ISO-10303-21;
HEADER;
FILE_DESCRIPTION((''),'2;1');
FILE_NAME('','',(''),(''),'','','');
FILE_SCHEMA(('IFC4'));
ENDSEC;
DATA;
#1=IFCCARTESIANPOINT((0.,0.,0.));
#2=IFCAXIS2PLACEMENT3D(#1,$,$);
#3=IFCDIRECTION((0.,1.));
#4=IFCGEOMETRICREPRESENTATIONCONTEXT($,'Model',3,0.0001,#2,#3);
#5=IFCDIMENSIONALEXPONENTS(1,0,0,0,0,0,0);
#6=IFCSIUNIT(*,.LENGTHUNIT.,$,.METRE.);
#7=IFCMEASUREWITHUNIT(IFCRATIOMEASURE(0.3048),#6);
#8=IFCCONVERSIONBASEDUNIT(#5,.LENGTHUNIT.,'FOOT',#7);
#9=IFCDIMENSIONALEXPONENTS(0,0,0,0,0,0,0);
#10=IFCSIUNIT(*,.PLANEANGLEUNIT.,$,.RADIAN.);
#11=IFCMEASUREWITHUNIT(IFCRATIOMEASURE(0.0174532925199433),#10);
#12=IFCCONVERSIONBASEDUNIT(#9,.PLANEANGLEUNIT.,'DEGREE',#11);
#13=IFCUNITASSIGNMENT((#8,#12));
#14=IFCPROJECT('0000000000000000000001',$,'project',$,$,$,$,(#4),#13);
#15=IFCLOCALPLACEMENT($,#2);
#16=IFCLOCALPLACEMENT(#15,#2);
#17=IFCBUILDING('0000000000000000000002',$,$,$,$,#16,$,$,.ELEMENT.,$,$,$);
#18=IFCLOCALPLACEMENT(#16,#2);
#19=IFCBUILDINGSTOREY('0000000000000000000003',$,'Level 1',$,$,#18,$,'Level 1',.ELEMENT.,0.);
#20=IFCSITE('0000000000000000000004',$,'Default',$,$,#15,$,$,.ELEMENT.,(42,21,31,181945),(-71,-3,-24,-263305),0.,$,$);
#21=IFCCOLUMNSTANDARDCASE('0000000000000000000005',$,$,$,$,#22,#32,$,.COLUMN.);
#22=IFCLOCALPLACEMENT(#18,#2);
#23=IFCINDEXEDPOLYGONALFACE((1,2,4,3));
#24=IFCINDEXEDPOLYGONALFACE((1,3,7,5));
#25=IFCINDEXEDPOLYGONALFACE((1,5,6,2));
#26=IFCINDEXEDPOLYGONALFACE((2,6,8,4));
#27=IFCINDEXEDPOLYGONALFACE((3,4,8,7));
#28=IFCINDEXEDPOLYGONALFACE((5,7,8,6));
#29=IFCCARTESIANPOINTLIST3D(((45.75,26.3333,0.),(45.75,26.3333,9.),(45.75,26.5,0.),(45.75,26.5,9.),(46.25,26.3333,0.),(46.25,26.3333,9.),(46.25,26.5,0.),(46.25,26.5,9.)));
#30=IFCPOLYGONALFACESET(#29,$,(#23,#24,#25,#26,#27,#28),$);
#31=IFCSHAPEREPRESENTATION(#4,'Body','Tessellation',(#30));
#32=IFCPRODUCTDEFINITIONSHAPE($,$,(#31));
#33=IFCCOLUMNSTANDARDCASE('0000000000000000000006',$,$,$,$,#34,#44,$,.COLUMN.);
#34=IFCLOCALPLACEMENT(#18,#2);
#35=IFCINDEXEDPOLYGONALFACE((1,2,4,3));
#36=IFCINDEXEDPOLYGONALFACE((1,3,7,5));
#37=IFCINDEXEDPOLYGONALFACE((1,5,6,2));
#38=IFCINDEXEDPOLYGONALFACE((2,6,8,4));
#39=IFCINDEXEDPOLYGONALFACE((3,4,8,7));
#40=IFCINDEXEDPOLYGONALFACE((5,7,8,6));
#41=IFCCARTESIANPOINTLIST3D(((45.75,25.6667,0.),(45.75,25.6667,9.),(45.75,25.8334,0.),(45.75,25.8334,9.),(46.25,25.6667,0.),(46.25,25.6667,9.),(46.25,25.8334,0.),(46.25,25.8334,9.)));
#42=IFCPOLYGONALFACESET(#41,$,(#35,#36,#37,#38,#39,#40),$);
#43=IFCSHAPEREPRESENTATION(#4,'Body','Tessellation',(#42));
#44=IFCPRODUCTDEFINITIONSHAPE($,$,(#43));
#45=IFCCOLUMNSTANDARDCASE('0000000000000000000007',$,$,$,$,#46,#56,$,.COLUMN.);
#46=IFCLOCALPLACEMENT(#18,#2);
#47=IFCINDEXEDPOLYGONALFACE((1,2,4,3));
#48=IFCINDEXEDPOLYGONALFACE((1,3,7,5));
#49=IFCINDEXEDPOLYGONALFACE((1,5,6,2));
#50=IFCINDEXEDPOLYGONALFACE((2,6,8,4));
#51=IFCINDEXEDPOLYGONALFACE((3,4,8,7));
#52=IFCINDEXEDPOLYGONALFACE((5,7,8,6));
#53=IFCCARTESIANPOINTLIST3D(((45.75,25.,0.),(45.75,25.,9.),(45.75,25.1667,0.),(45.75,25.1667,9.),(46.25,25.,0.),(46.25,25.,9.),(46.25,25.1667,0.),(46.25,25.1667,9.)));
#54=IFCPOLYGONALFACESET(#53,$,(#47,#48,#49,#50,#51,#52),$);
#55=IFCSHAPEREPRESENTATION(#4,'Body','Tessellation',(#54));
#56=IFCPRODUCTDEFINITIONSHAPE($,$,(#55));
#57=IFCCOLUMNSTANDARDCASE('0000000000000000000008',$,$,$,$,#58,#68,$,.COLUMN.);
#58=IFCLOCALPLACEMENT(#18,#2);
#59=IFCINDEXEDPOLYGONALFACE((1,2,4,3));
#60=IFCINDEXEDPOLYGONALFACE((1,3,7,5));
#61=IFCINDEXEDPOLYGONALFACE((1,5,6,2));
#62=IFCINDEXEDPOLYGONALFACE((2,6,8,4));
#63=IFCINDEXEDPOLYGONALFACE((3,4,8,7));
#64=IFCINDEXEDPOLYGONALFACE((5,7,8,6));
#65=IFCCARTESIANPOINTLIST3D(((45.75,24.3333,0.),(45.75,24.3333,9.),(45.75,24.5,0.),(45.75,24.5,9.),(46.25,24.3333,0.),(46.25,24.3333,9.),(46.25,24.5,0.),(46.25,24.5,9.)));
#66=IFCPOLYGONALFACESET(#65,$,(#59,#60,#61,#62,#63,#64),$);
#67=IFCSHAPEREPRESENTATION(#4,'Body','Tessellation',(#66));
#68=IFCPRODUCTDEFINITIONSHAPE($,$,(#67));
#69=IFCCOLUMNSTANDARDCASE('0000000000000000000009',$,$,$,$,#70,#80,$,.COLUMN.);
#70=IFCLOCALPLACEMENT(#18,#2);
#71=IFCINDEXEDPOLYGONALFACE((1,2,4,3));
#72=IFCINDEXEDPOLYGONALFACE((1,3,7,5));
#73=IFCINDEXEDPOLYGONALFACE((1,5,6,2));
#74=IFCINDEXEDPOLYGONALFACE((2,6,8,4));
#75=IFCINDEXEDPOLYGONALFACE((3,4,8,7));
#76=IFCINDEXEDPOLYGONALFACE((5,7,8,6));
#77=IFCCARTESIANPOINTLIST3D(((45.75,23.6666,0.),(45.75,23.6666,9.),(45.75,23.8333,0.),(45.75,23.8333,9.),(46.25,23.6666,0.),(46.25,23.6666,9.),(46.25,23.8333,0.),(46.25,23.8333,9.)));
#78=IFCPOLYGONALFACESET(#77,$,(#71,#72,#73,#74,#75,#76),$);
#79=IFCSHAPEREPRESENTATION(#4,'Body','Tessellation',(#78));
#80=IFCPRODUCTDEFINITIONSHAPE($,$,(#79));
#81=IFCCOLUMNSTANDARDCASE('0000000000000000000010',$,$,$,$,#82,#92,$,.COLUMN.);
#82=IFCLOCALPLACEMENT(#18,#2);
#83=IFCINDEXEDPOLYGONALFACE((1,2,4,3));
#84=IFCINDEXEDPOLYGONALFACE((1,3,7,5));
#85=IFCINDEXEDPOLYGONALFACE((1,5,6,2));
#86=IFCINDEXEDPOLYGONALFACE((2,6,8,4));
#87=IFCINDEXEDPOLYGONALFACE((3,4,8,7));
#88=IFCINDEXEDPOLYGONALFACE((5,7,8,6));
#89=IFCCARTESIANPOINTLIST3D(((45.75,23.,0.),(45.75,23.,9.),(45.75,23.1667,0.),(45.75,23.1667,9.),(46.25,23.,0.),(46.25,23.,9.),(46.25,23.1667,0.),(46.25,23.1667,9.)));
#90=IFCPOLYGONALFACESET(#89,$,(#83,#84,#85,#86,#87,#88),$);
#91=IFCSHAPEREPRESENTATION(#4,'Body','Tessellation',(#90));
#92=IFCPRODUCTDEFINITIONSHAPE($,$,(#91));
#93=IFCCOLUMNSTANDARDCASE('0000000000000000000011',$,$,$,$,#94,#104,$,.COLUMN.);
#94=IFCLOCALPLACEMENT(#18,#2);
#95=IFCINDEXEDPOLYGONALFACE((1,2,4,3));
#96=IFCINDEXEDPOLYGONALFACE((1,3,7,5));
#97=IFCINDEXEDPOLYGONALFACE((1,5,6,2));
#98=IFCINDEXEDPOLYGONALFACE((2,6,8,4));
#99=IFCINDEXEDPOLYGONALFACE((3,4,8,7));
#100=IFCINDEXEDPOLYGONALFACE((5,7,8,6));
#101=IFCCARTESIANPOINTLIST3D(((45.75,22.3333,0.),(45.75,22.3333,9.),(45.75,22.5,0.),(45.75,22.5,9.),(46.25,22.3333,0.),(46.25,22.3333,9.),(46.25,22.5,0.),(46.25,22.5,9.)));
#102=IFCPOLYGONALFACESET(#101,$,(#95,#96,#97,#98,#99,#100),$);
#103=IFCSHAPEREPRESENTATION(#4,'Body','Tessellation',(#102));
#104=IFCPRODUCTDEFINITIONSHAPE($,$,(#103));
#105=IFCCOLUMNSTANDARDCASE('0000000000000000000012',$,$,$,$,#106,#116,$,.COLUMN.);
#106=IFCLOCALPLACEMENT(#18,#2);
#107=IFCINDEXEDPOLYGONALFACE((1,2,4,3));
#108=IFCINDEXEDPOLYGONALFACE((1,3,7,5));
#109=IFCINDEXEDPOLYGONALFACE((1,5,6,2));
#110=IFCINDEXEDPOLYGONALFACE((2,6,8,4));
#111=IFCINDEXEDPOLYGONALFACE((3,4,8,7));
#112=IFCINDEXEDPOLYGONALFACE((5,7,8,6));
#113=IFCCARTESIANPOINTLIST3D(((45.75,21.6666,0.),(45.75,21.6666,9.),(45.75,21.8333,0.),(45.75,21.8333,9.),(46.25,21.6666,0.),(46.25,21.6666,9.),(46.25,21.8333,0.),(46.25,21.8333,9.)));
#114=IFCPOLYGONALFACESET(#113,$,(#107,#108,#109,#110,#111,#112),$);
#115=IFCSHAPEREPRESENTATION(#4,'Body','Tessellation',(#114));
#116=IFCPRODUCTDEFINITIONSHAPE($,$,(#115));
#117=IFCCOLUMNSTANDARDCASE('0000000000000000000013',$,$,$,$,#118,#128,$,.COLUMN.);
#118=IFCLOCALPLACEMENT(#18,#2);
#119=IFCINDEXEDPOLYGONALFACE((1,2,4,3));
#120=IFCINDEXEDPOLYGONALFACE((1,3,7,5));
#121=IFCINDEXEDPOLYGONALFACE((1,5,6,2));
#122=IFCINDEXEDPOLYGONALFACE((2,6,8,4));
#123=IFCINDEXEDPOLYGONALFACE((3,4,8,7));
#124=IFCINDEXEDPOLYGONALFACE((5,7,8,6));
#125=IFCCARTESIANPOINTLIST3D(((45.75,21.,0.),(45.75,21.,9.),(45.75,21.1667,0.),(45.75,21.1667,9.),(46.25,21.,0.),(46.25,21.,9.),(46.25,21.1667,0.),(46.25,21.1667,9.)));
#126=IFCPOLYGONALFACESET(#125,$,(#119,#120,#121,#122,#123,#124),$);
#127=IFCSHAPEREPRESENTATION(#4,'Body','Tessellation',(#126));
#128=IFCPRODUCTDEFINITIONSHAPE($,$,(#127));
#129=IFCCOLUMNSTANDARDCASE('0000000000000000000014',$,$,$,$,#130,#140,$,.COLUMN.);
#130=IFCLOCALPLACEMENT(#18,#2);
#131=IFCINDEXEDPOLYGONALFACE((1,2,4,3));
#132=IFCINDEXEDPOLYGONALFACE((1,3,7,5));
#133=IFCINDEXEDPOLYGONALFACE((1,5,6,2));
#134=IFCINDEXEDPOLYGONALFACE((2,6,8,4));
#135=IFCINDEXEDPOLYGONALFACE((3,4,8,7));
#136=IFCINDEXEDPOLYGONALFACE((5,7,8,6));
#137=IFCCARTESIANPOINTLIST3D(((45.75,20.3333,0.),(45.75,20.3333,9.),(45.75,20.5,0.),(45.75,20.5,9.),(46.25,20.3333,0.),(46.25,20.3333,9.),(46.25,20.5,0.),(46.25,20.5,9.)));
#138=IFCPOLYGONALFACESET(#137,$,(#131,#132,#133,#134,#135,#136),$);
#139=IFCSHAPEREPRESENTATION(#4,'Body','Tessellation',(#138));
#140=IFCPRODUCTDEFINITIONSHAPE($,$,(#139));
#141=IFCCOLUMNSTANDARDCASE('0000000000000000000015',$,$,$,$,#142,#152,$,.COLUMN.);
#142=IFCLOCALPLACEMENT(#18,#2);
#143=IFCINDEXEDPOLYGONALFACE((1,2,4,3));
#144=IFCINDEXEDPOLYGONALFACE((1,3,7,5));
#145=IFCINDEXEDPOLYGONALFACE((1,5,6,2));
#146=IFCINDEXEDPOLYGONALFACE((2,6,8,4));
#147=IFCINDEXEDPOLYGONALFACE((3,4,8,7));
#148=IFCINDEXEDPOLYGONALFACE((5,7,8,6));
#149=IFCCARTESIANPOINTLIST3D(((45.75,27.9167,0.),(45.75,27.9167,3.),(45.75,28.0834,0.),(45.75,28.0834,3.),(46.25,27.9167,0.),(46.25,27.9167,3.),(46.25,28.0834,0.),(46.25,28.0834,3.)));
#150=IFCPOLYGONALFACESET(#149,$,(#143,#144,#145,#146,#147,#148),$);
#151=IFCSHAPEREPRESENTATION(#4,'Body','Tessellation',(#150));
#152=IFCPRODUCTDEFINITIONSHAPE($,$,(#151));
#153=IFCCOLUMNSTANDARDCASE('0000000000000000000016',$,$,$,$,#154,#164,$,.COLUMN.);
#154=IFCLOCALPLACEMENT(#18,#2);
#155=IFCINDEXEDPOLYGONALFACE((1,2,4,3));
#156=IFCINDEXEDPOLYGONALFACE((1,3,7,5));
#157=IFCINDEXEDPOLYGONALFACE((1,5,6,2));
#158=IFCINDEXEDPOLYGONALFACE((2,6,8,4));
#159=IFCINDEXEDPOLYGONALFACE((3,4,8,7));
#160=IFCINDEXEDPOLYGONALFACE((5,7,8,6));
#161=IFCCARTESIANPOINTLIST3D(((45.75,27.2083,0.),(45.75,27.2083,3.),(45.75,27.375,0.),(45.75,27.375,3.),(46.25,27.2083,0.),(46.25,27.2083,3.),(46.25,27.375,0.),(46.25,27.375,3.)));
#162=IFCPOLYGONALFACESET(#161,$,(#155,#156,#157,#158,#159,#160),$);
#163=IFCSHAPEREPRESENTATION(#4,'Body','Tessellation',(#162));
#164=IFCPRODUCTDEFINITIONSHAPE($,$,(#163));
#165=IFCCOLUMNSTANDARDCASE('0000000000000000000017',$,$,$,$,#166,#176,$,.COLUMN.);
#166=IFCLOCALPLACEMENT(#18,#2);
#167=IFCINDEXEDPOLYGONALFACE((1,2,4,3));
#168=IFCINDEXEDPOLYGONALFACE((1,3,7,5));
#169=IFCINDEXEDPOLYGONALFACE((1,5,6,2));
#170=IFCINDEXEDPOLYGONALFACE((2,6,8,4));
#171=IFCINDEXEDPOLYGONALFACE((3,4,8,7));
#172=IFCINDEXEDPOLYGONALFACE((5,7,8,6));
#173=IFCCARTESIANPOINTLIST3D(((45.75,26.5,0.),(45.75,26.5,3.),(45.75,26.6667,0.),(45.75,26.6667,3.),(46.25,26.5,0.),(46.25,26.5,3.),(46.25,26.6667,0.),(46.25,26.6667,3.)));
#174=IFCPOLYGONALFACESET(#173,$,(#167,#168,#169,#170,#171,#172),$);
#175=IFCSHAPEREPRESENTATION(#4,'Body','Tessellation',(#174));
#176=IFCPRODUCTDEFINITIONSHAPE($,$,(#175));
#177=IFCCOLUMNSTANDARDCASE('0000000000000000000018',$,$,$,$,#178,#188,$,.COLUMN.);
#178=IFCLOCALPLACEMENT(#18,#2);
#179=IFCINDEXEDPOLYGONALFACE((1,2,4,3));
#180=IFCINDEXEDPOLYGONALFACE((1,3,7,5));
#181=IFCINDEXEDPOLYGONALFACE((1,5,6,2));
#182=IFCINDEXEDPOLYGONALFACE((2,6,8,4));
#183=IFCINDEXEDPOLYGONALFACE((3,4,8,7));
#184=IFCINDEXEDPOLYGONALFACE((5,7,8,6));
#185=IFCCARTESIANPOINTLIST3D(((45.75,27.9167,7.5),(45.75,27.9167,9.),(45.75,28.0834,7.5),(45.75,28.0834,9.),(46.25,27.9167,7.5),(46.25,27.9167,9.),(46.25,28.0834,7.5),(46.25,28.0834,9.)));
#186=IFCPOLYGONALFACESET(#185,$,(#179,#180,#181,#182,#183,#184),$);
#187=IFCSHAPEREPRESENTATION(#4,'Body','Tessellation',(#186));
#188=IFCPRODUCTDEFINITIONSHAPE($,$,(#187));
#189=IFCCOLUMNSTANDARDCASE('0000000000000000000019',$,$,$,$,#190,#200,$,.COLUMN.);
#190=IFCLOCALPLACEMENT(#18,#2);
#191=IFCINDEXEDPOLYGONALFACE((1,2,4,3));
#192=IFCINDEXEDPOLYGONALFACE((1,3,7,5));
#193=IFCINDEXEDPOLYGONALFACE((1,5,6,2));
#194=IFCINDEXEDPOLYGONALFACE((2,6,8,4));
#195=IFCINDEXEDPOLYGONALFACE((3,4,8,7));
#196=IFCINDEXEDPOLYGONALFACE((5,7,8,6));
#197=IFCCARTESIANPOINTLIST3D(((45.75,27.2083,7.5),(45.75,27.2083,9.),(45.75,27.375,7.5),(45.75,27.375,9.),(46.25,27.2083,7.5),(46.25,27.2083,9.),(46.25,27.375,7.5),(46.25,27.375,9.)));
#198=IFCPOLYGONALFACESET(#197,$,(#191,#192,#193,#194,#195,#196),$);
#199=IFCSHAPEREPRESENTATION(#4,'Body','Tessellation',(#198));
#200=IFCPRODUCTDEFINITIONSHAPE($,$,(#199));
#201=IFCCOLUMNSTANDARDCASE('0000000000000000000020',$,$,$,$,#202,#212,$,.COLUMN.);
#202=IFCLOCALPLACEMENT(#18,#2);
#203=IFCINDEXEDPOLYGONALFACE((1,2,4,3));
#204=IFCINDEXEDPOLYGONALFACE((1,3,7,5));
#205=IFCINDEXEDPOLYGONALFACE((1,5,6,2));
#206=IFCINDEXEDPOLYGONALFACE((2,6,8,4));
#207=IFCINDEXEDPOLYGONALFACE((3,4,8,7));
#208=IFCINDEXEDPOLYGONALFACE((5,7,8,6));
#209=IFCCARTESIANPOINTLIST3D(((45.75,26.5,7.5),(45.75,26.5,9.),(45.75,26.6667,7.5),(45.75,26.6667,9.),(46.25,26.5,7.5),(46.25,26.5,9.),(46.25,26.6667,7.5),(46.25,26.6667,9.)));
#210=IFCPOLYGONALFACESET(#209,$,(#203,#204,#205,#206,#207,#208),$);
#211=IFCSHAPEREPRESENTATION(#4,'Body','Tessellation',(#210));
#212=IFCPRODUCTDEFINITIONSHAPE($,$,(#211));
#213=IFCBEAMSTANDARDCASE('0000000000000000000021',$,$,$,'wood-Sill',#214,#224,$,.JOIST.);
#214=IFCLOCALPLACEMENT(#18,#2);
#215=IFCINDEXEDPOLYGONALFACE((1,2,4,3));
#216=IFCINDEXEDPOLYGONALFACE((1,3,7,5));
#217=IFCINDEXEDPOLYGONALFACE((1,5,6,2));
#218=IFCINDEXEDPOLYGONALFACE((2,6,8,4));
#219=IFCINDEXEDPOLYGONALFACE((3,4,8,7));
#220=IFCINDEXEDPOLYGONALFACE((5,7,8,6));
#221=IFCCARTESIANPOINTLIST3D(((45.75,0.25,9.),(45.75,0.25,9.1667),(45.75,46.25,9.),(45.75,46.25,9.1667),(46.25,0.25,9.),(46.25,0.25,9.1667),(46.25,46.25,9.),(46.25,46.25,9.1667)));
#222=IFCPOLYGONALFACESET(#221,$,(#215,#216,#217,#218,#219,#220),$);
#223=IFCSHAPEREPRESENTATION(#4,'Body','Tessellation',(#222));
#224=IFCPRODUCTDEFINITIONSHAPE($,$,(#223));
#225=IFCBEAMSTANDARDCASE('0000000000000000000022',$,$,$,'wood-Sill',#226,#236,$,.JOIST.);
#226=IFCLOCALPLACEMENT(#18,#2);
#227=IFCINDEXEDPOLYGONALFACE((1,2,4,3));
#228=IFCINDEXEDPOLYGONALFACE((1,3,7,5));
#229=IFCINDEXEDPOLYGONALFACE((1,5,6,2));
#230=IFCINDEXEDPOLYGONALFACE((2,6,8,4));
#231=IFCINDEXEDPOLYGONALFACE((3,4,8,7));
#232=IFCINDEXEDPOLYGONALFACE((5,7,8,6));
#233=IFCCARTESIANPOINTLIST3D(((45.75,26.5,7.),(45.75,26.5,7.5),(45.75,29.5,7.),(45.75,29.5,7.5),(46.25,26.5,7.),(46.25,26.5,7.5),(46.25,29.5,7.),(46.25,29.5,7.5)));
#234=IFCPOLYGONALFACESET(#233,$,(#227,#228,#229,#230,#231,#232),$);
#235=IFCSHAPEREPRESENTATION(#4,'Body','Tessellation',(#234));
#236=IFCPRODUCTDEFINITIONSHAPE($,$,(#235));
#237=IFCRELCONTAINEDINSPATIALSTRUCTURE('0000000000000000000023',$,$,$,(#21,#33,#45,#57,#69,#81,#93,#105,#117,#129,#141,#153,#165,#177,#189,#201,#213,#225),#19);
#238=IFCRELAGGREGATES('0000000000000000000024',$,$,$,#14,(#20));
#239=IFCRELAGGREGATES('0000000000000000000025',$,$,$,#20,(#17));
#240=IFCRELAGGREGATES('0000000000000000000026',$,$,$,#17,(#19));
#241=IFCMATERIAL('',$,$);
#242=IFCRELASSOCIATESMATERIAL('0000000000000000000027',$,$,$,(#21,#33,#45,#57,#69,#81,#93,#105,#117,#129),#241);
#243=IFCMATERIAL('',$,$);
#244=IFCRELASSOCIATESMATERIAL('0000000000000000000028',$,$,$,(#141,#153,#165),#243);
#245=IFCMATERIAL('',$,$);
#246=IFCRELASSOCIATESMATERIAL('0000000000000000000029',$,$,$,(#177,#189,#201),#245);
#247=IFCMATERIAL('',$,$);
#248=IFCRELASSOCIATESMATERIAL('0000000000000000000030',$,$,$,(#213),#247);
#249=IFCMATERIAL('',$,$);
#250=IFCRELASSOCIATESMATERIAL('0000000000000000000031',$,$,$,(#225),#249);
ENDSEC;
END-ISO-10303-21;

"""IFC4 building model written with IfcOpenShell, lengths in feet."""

from ifc_helpers import new_model, entity, si_unit, converted_unit, direction, frame, origin, place, context, project, spatial, rectangle, extrude, material, element, save


model = new_model("IFC4")

# Units and contexts
model_context = context("Model", 3, precision=0.0001, world=origin(), true_north=direction((0.0, 1.0)))
ifc_project = project(units=[converted_unit("LENGTHUNIT", "FOOT", entity("IfcRatioMeasure", 0.3048), si_unit("LENGTHUNIT", "METRE"), dimensions=[1, 0, 0, 0, 0, 0, 0]), converted_unit("PLANEANGLEUNIT", "DEGREE", entity("IfcRatioMeasure", 0.0174532925199433), si_unit("PLANEANGLEUNIT", "RADIAN"), dimensions=[0, 0, 0, 0, 0, 0, 0])], contexts=[model_context])

# Site, building, storey
site_placement = place(None, origin())
site = spatial("IfcSite", under=ifc_project, at=site_placement, Name="Default", CompositionType="ELEMENT", RefLatitude=(42, 21, 31, 181945), RefLongitude=(-71, -3, -24, -263305), RefElevation=0.0)
building_placement = place(site_placement, origin())
building = spatial("IfcBuilding", under=site, at=building_placement, CompositionType="ELEMENT")
storey_placement = place(building_placement, origin())
storey = spatial("IfcBuildingStorey", under=building, at=storey_placement, Name="Level 1", LongName="Level 1", CompositionType="ELEMENT", Elevation=0.0)

# Columns
ifc_material_1 = material(Name="")
placement_1 = place(storey_placement, frame((46.0, 46.25, 0.0), z_axis=(0.0, 0.0, 1.0), x_axis=(0.0, -1.0, 0.0)))
for number, where, z_axis, x_axis in (
    (1, (19.8334, 0.0, 0.0), (0.0, 0.0, 1.0), (1.0, 0.0, 0.0)),
    (2, (20.5, 0.0, 0.0), (0.0, 0.0, 1.0), (1.0, 0.0, 0.0)),
    (3, (21.1667, 0.0, 0.0), (0.0, 0.0, 1.0), (1.0, 0.0, 0.0)),
    (4, (21.8334, 0.0, 0.0), (0.0, 0.0, 1.0), (1.0, 0.0, 0.0)),
    (5, (22.5001, 0.0, 0.0), (0.0, 0.0, 1.0), (1.0, 0.0, 0.0)),
    (6, (23.1667, 0.0, 0.0), (0.0, 0.0, 1.0), (1.0, 0.0, 0.0)),
    (7, (23.8334, 0.0, 0.0), (0.0, 0.0, 1.0), (1.0, 0.0, 0.0)),
    (8, (24.5001, 0.0, 0.0), (0.0, 0.0, 1.0), (1.0, 0.0, 0.0)),
    (9, (25.1667, 0.0, 0.0), (0.0, 0.0, 1.0), (1.0, 0.0, 0.0)),
    (10, (25.8334, 0.0, 0.0), (0.0, 0.0, 1.0), (1.0, 0.0, 0.0)),
):
    element("IfcColumnStandardCase", number, at=place(placement_1, frame(where, z_axis=z_axis, x_axis=x_axis)), inside=storey, material=ifc_material_1, PredefinedType="COLUMN", context=model_context, shape_type="SweptSolid", body=[
        extrude(rectangle(XDim=0.1667, YDim=0.5), origin(), (0.0, 0.0, 1.0), 9.0),
    ])
ifc_material_2 = material(Name="")
for number, where, z_axis, x_axis in (
    (11, (18.25, 0.0, 0.0), (0.0, 0.0, 1.0), (1.0, 0.0, 0.0)),
    (12, (18.9584, 0.0, 0.0), (0.0, 0.0, 1.0), (1.0, 0.0, 0.0)),
    (13, (19.6667, 0.0, 0.0), (0.0, 0.0, 1.0), (1.0, 0.0, 0.0)),
):
    element("IfcColumnStandardCase", number, at=place(placement_1, frame(where, z_axis=z_axis, x_axis=x_axis)), inside=storey, material=ifc_material_2, PredefinedType="COLUMN", context=model_context, shape_type="SweptSolid", body=[
        extrude(rectangle(XDim=0.1667, YDim=0.5), origin(), (0.0, 0.0, 1.0), 3.0),
    ])
ifc_material_3 = material(Name="")
for number, where, z_axis, x_axis in (
    (14, (18.25, 0.0, 7.5), (0.0, 0.0, 1.0), (1.0, 0.0, 0.0)),
    (15, (18.9584, 0.0, 7.5), (0.0, 0.0, 1.0), (1.0, 0.0, 0.0)),
    (16, (19.6667, 0.0, 7.5), (0.0, 0.0, 1.0), (1.0, 0.0, 0.0)),
):
    element("IfcColumnStandardCase", number, at=place(placement_1, frame(where, z_axis=z_axis, x_axis=x_axis)), inside=storey, material=ifc_material_3, PredefinedType="COLUMN", context=model_context, shape_type="SweptSolid", body=[
        extrude(rectangle(XDim=0.1667, YDim=0.5), origin(), (0.0, 0.0, 1.0), 1.5),
    ])

# Beams
ifc_material_4 = material(Name="")
beam_1_placement = place(placement_1, frame((23.0, 0.0, 9.0), z_axis=(0.0, 0.0, 1.0), x_axis=(1.0, 0.0, 0.0)))
element("IfcBeamStandardCase", 17, at=beam_1_placement, inside=storey, material=ifc_material_4, ObjectType="wood-Sill", PredefinedType="JOIST", context=model_context, shape_type="SweptSolid", body=[
    extrude(rectangle(XDim=46.0, YDim=0.5), origin(), (0.0, 0.0, 1.0), 0.1667),
])
ifc_material_5 = material(Name="")
for number, where, z_axis, x_axis in (
    (18, (18.25, 0.0, 7.0), (0.0, 0.0, 1.0), (1.0, 0.0, 0.0)),
):
    element("IfcBeamStandardCase", number, at=place(placement_1, frame(where, z_axis=z_axis, x_axis=x_axis)), inside=storey, material=ifc_material_5, ObjectType="wood-Sill", PredefinedType="JOIST", context=model_context, shape_type="SweptSolid", body=[
        extrude(rectangle(XDim=3.0, YDim=0.5), origin(), (0.0, 0.0, 1.0), 0.5),
    ])

save(model, "model.ifc")
